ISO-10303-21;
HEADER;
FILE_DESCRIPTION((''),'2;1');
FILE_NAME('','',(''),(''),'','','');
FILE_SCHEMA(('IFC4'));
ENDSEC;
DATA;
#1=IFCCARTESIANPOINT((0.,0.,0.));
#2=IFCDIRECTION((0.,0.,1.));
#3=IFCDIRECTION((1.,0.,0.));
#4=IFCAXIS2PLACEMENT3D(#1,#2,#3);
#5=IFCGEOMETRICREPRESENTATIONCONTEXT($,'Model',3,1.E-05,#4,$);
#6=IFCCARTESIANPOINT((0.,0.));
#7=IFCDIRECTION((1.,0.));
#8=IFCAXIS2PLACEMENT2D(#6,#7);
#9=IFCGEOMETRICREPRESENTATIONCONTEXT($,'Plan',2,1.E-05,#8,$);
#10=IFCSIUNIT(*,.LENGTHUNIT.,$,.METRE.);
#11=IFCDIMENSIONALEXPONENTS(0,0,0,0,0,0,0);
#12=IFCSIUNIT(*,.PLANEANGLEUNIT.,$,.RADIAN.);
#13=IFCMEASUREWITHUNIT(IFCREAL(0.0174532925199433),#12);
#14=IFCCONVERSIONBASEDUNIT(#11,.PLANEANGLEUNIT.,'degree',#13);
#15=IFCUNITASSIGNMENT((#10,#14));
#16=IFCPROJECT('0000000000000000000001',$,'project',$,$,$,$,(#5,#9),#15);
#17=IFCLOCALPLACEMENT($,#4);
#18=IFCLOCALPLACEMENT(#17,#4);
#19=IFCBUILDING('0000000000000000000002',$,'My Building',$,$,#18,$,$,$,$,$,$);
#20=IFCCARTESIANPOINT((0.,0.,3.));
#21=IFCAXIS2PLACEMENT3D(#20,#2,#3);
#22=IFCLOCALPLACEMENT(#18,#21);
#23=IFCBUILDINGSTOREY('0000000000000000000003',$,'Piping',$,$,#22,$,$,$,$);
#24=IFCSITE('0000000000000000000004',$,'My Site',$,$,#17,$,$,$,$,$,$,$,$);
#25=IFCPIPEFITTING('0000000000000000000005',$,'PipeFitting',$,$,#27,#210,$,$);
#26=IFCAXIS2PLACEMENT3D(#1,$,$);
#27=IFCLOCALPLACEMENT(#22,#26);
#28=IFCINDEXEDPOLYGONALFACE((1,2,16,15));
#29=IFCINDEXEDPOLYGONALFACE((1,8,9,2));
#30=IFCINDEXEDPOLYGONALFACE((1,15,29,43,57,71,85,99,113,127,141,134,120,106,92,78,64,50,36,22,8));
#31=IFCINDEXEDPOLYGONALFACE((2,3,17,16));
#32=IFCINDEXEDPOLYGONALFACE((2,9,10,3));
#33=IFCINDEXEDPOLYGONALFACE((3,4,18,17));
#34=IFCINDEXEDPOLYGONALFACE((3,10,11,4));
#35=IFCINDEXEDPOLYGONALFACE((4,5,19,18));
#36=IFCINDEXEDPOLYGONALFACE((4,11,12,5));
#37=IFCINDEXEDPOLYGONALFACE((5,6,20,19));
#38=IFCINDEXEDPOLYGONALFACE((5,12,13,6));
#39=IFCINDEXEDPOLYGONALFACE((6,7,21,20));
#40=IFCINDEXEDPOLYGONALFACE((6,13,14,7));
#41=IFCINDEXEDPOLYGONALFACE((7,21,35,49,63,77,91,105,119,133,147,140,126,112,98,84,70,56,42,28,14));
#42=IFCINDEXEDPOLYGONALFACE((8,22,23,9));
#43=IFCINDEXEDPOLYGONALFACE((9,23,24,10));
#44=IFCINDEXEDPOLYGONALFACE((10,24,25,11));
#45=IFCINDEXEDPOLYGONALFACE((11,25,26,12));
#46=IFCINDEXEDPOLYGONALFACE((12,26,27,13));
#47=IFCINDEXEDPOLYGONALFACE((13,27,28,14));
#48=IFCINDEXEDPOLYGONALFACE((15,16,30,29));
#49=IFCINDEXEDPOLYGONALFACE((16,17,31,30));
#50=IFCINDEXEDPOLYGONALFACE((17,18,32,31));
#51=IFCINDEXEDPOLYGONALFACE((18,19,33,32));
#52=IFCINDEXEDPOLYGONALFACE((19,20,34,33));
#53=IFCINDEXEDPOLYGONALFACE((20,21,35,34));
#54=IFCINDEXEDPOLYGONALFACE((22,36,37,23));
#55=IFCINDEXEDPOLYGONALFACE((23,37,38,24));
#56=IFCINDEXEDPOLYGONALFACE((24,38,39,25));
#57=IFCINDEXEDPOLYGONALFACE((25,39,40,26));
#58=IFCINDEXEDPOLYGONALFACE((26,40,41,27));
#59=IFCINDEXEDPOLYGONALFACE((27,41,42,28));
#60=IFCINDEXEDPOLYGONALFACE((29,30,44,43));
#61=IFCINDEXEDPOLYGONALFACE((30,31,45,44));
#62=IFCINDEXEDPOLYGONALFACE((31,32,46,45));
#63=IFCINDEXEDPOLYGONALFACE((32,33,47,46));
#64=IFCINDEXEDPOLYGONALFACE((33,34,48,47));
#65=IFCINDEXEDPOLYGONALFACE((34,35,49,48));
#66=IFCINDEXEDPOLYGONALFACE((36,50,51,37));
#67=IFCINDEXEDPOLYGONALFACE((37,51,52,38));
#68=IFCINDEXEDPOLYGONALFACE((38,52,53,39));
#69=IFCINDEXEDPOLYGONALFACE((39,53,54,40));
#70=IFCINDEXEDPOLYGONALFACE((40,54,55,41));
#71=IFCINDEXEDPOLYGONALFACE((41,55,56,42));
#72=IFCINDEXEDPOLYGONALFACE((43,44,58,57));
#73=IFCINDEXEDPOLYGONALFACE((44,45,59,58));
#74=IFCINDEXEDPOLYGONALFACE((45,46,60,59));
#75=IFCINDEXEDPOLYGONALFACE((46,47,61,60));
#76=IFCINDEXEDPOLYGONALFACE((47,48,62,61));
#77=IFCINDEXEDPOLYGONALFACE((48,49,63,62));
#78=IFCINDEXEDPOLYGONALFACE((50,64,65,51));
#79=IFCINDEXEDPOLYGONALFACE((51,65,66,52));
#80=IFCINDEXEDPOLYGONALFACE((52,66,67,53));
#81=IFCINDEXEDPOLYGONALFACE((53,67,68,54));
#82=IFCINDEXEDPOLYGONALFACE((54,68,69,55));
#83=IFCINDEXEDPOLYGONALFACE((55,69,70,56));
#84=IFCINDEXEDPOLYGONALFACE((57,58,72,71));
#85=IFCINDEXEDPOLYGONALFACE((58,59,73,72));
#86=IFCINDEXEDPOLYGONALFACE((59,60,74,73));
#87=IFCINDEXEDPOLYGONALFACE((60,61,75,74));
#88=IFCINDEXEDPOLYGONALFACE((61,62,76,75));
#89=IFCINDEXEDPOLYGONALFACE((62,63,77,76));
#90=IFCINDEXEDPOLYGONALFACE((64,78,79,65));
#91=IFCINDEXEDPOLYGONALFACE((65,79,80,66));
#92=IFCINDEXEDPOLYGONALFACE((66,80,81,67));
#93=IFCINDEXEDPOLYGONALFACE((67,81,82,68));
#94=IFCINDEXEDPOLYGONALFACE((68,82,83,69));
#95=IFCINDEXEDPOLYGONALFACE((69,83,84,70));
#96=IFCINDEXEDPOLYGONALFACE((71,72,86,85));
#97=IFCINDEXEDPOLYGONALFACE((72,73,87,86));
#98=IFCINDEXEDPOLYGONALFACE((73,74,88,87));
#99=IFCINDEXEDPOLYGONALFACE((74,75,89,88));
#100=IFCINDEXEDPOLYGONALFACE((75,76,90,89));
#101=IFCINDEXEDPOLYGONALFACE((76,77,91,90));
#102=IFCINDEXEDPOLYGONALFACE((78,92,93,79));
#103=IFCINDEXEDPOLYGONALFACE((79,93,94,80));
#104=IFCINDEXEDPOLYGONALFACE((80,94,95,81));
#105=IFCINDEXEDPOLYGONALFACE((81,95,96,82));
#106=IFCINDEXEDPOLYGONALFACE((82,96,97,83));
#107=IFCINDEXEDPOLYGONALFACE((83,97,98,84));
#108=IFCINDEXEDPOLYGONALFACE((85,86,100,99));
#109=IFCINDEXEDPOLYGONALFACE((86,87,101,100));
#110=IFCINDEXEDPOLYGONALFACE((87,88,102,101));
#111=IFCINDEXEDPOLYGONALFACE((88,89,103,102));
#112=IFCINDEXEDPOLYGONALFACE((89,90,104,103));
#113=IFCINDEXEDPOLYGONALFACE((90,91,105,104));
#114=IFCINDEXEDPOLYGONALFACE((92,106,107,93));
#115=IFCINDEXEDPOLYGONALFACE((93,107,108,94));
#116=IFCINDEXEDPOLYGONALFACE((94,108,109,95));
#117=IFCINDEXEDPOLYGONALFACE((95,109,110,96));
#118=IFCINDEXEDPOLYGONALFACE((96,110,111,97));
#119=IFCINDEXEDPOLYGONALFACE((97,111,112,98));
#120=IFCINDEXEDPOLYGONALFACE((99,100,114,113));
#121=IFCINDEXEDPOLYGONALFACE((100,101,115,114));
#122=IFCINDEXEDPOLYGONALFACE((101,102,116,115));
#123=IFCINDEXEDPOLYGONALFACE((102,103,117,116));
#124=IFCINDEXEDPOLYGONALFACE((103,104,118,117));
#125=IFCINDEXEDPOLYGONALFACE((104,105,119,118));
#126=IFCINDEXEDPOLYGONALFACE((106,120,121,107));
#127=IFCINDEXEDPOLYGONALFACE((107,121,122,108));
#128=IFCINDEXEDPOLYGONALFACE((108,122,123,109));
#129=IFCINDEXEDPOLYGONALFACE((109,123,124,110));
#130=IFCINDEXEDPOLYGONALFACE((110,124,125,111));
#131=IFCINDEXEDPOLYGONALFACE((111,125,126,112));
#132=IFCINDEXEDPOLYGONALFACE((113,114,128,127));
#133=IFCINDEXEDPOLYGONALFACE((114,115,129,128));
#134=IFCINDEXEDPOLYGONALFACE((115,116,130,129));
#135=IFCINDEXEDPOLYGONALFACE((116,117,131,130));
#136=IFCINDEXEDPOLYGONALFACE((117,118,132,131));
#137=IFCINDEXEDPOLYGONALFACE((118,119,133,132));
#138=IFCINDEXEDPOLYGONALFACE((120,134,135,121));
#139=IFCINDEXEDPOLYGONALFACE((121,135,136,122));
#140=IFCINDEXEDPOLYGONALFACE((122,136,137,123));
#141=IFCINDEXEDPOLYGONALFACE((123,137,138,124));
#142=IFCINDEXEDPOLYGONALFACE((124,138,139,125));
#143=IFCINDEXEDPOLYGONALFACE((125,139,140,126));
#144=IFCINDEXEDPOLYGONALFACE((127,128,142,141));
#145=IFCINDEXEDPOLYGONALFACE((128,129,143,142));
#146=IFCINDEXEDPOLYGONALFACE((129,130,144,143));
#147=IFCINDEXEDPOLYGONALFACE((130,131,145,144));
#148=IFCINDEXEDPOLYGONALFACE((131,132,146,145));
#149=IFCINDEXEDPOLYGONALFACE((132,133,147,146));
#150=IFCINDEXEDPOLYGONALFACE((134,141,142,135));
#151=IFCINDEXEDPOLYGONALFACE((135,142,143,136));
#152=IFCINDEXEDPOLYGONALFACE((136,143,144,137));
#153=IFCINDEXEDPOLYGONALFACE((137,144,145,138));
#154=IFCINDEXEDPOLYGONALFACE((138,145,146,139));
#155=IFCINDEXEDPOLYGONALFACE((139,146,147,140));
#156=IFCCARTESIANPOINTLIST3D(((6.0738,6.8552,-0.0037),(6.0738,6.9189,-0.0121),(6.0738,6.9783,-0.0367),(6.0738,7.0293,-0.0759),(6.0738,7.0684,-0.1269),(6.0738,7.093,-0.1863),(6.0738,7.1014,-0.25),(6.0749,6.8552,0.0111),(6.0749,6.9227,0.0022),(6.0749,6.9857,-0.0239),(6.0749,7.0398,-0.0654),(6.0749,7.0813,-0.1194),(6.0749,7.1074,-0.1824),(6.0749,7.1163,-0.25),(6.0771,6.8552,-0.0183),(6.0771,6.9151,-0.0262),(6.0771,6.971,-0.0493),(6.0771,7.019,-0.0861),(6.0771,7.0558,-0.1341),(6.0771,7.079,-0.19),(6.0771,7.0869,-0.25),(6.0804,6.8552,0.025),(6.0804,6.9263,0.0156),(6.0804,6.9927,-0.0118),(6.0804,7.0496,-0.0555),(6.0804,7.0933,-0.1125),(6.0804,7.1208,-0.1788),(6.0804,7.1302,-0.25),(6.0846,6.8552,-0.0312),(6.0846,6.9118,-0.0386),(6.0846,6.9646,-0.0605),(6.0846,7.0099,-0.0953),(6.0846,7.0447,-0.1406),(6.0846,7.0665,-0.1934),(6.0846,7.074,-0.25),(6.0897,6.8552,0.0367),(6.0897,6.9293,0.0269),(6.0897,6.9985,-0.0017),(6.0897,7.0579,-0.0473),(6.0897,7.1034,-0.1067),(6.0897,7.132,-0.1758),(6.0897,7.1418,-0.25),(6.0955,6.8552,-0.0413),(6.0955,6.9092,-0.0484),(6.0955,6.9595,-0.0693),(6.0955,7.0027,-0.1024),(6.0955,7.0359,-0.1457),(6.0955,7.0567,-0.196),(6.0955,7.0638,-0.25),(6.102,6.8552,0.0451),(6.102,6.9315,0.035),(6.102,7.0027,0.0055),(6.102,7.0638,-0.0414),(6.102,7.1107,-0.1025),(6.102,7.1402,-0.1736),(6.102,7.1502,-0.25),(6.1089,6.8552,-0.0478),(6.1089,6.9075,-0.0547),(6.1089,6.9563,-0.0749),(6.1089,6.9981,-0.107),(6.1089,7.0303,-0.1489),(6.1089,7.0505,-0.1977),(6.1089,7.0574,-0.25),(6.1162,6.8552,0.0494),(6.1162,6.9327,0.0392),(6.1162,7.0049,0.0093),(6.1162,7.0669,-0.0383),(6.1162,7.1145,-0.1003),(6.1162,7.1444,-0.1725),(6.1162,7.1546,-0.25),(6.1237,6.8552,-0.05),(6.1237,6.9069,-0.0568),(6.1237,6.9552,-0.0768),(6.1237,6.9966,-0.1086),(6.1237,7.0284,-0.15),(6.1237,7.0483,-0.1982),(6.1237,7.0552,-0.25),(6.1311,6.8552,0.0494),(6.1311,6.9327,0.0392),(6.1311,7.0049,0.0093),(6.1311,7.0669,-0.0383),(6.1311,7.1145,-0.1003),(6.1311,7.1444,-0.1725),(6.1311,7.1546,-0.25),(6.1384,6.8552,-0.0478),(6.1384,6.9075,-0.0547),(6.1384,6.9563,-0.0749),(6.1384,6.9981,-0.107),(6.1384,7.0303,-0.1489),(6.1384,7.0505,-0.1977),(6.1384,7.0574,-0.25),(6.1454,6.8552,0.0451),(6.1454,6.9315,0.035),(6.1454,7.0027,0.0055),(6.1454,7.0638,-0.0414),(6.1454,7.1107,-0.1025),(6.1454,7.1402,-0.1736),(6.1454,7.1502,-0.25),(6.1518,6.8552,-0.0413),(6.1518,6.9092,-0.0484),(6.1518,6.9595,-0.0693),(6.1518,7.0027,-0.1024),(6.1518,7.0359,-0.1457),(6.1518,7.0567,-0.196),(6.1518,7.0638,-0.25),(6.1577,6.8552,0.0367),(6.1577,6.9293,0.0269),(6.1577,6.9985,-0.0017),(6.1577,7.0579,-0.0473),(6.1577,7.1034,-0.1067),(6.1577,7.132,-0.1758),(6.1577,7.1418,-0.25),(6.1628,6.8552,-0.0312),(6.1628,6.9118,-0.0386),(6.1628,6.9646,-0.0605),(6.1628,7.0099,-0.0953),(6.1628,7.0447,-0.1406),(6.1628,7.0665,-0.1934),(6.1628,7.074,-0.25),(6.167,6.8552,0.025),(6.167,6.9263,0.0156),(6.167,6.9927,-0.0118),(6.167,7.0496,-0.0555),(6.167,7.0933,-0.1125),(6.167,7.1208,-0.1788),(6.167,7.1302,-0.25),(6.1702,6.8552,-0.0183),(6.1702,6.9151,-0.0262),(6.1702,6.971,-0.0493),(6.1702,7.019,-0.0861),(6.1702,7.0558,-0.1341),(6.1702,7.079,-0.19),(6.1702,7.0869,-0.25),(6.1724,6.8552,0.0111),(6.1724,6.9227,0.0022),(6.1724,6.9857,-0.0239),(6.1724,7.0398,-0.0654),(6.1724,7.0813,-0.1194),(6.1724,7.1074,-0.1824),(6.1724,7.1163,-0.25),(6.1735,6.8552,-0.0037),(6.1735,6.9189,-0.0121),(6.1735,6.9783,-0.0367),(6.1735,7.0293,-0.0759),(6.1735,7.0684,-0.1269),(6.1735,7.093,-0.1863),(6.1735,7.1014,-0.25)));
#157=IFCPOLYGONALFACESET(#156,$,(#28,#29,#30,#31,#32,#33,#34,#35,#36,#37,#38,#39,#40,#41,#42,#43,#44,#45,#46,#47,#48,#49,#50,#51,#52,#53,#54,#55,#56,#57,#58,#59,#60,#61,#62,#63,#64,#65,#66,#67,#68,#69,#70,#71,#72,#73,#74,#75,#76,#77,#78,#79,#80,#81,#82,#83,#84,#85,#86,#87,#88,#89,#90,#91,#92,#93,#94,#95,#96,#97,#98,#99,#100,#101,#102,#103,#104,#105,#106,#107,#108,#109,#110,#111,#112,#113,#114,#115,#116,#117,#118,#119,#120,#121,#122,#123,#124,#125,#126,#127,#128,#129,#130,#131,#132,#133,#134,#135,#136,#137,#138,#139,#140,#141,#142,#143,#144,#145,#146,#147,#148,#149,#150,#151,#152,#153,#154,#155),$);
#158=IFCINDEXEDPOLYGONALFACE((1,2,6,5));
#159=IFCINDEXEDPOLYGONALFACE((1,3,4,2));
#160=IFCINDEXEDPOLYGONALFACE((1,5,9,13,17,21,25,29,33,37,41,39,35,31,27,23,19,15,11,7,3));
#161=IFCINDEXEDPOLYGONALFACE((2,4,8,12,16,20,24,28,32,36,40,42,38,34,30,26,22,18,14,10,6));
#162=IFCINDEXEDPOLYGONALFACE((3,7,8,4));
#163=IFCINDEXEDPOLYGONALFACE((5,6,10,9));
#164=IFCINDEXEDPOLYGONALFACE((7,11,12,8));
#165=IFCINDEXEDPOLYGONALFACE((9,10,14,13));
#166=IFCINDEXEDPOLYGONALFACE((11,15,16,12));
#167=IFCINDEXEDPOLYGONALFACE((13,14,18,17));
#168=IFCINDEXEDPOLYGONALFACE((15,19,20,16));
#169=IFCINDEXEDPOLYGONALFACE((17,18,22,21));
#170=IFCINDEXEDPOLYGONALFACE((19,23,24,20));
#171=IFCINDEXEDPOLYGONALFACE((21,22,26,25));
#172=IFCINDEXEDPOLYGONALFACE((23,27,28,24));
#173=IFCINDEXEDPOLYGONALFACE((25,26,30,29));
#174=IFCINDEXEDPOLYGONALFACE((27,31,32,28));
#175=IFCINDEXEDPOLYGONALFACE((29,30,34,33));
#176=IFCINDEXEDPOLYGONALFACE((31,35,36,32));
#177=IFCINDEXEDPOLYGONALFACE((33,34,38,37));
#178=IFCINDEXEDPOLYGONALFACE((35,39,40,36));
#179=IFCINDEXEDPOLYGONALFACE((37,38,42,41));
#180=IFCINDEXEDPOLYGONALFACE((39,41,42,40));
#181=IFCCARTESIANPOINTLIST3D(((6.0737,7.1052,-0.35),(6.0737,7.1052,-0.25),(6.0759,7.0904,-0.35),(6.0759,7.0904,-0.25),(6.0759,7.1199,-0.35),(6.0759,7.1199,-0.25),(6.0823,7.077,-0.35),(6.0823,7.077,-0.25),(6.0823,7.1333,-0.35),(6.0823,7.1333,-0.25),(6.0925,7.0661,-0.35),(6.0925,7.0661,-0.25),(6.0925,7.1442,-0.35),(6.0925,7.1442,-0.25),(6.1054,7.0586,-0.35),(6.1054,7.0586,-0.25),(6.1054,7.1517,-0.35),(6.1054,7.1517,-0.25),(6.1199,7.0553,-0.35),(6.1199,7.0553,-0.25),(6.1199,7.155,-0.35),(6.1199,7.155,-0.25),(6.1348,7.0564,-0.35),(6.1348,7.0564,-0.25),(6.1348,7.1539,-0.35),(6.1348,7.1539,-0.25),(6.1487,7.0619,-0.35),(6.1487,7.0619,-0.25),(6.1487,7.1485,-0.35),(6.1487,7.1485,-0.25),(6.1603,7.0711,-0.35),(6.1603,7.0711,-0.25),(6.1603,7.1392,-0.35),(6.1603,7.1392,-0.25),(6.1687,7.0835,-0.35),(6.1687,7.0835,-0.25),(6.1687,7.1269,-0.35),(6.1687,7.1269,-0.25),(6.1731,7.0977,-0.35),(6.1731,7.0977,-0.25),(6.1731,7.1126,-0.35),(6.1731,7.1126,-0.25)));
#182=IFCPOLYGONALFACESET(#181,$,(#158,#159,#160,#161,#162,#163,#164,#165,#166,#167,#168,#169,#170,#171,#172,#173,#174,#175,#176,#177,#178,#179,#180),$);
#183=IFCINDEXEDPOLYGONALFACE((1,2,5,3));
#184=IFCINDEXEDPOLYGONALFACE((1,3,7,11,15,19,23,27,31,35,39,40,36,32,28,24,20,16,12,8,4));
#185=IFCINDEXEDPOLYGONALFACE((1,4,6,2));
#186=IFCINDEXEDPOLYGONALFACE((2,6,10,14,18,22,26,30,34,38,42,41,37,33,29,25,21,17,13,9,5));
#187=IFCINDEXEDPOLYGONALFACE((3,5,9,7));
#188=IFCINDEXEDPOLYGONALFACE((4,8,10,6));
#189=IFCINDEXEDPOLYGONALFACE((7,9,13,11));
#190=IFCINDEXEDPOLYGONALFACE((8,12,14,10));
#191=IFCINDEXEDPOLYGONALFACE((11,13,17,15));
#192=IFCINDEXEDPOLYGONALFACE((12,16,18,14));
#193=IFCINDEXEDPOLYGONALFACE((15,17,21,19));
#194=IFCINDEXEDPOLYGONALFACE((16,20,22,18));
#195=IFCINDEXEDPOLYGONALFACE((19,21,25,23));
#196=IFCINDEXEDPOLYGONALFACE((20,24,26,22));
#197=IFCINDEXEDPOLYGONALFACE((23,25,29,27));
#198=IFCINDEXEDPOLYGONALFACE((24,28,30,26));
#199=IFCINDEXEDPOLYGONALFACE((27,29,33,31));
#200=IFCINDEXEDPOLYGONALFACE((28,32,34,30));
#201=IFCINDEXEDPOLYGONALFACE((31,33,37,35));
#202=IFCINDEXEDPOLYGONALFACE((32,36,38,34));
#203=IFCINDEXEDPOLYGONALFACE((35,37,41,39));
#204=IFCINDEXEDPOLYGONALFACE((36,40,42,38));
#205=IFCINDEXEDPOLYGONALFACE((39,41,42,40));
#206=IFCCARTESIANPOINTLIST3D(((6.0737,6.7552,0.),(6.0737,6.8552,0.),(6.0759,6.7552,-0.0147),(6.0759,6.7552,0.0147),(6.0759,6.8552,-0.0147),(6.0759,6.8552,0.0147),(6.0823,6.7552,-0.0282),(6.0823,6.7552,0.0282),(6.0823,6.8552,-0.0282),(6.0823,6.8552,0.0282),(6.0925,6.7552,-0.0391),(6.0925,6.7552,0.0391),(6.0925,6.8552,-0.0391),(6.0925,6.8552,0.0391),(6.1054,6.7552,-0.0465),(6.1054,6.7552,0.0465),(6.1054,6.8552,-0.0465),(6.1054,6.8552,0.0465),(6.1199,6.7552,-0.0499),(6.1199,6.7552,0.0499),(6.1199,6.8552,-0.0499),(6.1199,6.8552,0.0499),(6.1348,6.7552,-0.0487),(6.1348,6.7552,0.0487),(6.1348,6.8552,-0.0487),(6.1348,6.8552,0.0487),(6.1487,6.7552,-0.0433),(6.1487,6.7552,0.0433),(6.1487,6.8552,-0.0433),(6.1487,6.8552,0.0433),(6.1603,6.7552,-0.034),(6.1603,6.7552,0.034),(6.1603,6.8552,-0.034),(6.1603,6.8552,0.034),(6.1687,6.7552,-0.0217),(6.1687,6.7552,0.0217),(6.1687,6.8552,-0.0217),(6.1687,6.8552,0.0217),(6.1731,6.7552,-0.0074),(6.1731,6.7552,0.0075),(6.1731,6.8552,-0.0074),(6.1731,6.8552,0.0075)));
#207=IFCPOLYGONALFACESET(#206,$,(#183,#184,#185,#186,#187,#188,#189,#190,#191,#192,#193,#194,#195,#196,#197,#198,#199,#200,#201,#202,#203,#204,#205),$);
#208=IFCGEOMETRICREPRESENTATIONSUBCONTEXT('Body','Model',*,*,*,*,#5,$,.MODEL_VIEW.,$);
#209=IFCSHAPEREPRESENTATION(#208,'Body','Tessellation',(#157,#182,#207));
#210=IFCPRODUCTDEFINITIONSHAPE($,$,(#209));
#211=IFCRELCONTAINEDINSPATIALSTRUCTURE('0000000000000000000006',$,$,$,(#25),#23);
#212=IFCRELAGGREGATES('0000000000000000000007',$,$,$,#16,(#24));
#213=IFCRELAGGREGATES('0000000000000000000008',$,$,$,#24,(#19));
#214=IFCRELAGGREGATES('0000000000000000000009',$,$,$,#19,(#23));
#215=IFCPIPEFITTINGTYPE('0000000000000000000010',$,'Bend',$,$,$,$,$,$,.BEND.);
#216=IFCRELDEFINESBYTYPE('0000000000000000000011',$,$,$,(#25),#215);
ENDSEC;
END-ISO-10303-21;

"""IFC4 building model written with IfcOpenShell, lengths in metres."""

from ifc_helpers import new_model, entity, si_unit, converted_unit, frame, origin_with_axes, origin_2d_with_axis, place, context, subcontext, project, spatial, circle, extrude, source, transform, mapped, type_object, type_shapes, element, save


model = new_model("IFC4")

# Units and contexts
model_context = context("Model", 3, precision=1e-05, world=origin_with_axes())
plan_context = context("Plan", 2, precision=1e-05, world=origin_2d_with_axis())
body_context = subcontext(model_context, "Body", "Model", "MODEL_VIEW")
ifc_project = project(units=[si_unit("LENGTHUNIT", "METRE"), converted_unit("PLANEANGLEUNIT", "degree", entity("IfcReal", 0.0174532925199433), si_unit("PLANEANGLEUNIT", "RADIAN"), dimensions=[0, 0, 0, 0, 0, 0, 0])], contexts=[model_context, plan_context])

# Site, building, storey
site_placement = place(None, origin_with_axes())
site = spatial("IfcSite", under=ifc_project, at=site_placement, Name="My Site")
building_placement = place(site_placement, origin_with_axes())
building = spatial("IfcBuilding", under=site, at=building_placement, Name="My Building")
storey_placement = place(building_placement, frame((0.0, 0.0, 3.0), z_axis=(0.0, 0.0, 1.0), x_axis=(1.0, 0.0, 0.0)))
storey = spatial("IfcBuildingStorey", under=building, at=storey_placement, Name="Piping")

# Shared definitions
pipe_fitting_type = type_object("IfcPipeFittingType", Name="Bend", PredefinedType="BEND")
shared_shape = source(origin_with_axes(), body_context, "Body", "SolidModel", [
    entity("IfcSweptDiskSolid", entity("IfcIndexedPolyCurve", entity("IfcCartesianPointList3D", [[0.0, 0.0, -0.1], [0.0, -0.0732, -0.2768], [0.0, -0.25, -0.35]]), [entity("IfcArcIndex", [1, 2, 3])]), 0.05),
    extrude(circle(Radius=0.05), origin_with_axes(), (0.0, 0.0, -1.0), 0.1),
    extrude(circle(Radius=0.05), frame((0.0, -0.25, -0.35), z_axis=(0.0, -1.0, 0.0), x_axis=(1.0, 0.0, 0.0)), (0.0, 0.0, 1.0), 0.1),
])
type_shapes(pipe_fitting_type, [shared_shape])

# Pipe fitting
for number, where, z_axis, x_axis, name in (
    (1, (6.1237, 7.1052, -0.35), (0.0, 0.0, -1.0), (-1.0, 0.0, 0.0), "PipeFitting"),
):
    element("IfcPipeFitting", number, at=place(storey_placement, frame(where, z_axis=z_axis, x_axis=x_axis)), inside=storey, type_object=pipe_fitting_type, Name=name, context=body_context, shape_type="MappedRepresentation", body=[
        mapped(shared_shape, transform((0.0, 0.0, 0.0), x_axis=(1.0, 0.0, 0.0), y_axis=(0.0, 1.0, 0.0), z_axis=(0.0, 0.0, 1.0), scale=1.0)),
    ])

save(model, "model.ifc")
